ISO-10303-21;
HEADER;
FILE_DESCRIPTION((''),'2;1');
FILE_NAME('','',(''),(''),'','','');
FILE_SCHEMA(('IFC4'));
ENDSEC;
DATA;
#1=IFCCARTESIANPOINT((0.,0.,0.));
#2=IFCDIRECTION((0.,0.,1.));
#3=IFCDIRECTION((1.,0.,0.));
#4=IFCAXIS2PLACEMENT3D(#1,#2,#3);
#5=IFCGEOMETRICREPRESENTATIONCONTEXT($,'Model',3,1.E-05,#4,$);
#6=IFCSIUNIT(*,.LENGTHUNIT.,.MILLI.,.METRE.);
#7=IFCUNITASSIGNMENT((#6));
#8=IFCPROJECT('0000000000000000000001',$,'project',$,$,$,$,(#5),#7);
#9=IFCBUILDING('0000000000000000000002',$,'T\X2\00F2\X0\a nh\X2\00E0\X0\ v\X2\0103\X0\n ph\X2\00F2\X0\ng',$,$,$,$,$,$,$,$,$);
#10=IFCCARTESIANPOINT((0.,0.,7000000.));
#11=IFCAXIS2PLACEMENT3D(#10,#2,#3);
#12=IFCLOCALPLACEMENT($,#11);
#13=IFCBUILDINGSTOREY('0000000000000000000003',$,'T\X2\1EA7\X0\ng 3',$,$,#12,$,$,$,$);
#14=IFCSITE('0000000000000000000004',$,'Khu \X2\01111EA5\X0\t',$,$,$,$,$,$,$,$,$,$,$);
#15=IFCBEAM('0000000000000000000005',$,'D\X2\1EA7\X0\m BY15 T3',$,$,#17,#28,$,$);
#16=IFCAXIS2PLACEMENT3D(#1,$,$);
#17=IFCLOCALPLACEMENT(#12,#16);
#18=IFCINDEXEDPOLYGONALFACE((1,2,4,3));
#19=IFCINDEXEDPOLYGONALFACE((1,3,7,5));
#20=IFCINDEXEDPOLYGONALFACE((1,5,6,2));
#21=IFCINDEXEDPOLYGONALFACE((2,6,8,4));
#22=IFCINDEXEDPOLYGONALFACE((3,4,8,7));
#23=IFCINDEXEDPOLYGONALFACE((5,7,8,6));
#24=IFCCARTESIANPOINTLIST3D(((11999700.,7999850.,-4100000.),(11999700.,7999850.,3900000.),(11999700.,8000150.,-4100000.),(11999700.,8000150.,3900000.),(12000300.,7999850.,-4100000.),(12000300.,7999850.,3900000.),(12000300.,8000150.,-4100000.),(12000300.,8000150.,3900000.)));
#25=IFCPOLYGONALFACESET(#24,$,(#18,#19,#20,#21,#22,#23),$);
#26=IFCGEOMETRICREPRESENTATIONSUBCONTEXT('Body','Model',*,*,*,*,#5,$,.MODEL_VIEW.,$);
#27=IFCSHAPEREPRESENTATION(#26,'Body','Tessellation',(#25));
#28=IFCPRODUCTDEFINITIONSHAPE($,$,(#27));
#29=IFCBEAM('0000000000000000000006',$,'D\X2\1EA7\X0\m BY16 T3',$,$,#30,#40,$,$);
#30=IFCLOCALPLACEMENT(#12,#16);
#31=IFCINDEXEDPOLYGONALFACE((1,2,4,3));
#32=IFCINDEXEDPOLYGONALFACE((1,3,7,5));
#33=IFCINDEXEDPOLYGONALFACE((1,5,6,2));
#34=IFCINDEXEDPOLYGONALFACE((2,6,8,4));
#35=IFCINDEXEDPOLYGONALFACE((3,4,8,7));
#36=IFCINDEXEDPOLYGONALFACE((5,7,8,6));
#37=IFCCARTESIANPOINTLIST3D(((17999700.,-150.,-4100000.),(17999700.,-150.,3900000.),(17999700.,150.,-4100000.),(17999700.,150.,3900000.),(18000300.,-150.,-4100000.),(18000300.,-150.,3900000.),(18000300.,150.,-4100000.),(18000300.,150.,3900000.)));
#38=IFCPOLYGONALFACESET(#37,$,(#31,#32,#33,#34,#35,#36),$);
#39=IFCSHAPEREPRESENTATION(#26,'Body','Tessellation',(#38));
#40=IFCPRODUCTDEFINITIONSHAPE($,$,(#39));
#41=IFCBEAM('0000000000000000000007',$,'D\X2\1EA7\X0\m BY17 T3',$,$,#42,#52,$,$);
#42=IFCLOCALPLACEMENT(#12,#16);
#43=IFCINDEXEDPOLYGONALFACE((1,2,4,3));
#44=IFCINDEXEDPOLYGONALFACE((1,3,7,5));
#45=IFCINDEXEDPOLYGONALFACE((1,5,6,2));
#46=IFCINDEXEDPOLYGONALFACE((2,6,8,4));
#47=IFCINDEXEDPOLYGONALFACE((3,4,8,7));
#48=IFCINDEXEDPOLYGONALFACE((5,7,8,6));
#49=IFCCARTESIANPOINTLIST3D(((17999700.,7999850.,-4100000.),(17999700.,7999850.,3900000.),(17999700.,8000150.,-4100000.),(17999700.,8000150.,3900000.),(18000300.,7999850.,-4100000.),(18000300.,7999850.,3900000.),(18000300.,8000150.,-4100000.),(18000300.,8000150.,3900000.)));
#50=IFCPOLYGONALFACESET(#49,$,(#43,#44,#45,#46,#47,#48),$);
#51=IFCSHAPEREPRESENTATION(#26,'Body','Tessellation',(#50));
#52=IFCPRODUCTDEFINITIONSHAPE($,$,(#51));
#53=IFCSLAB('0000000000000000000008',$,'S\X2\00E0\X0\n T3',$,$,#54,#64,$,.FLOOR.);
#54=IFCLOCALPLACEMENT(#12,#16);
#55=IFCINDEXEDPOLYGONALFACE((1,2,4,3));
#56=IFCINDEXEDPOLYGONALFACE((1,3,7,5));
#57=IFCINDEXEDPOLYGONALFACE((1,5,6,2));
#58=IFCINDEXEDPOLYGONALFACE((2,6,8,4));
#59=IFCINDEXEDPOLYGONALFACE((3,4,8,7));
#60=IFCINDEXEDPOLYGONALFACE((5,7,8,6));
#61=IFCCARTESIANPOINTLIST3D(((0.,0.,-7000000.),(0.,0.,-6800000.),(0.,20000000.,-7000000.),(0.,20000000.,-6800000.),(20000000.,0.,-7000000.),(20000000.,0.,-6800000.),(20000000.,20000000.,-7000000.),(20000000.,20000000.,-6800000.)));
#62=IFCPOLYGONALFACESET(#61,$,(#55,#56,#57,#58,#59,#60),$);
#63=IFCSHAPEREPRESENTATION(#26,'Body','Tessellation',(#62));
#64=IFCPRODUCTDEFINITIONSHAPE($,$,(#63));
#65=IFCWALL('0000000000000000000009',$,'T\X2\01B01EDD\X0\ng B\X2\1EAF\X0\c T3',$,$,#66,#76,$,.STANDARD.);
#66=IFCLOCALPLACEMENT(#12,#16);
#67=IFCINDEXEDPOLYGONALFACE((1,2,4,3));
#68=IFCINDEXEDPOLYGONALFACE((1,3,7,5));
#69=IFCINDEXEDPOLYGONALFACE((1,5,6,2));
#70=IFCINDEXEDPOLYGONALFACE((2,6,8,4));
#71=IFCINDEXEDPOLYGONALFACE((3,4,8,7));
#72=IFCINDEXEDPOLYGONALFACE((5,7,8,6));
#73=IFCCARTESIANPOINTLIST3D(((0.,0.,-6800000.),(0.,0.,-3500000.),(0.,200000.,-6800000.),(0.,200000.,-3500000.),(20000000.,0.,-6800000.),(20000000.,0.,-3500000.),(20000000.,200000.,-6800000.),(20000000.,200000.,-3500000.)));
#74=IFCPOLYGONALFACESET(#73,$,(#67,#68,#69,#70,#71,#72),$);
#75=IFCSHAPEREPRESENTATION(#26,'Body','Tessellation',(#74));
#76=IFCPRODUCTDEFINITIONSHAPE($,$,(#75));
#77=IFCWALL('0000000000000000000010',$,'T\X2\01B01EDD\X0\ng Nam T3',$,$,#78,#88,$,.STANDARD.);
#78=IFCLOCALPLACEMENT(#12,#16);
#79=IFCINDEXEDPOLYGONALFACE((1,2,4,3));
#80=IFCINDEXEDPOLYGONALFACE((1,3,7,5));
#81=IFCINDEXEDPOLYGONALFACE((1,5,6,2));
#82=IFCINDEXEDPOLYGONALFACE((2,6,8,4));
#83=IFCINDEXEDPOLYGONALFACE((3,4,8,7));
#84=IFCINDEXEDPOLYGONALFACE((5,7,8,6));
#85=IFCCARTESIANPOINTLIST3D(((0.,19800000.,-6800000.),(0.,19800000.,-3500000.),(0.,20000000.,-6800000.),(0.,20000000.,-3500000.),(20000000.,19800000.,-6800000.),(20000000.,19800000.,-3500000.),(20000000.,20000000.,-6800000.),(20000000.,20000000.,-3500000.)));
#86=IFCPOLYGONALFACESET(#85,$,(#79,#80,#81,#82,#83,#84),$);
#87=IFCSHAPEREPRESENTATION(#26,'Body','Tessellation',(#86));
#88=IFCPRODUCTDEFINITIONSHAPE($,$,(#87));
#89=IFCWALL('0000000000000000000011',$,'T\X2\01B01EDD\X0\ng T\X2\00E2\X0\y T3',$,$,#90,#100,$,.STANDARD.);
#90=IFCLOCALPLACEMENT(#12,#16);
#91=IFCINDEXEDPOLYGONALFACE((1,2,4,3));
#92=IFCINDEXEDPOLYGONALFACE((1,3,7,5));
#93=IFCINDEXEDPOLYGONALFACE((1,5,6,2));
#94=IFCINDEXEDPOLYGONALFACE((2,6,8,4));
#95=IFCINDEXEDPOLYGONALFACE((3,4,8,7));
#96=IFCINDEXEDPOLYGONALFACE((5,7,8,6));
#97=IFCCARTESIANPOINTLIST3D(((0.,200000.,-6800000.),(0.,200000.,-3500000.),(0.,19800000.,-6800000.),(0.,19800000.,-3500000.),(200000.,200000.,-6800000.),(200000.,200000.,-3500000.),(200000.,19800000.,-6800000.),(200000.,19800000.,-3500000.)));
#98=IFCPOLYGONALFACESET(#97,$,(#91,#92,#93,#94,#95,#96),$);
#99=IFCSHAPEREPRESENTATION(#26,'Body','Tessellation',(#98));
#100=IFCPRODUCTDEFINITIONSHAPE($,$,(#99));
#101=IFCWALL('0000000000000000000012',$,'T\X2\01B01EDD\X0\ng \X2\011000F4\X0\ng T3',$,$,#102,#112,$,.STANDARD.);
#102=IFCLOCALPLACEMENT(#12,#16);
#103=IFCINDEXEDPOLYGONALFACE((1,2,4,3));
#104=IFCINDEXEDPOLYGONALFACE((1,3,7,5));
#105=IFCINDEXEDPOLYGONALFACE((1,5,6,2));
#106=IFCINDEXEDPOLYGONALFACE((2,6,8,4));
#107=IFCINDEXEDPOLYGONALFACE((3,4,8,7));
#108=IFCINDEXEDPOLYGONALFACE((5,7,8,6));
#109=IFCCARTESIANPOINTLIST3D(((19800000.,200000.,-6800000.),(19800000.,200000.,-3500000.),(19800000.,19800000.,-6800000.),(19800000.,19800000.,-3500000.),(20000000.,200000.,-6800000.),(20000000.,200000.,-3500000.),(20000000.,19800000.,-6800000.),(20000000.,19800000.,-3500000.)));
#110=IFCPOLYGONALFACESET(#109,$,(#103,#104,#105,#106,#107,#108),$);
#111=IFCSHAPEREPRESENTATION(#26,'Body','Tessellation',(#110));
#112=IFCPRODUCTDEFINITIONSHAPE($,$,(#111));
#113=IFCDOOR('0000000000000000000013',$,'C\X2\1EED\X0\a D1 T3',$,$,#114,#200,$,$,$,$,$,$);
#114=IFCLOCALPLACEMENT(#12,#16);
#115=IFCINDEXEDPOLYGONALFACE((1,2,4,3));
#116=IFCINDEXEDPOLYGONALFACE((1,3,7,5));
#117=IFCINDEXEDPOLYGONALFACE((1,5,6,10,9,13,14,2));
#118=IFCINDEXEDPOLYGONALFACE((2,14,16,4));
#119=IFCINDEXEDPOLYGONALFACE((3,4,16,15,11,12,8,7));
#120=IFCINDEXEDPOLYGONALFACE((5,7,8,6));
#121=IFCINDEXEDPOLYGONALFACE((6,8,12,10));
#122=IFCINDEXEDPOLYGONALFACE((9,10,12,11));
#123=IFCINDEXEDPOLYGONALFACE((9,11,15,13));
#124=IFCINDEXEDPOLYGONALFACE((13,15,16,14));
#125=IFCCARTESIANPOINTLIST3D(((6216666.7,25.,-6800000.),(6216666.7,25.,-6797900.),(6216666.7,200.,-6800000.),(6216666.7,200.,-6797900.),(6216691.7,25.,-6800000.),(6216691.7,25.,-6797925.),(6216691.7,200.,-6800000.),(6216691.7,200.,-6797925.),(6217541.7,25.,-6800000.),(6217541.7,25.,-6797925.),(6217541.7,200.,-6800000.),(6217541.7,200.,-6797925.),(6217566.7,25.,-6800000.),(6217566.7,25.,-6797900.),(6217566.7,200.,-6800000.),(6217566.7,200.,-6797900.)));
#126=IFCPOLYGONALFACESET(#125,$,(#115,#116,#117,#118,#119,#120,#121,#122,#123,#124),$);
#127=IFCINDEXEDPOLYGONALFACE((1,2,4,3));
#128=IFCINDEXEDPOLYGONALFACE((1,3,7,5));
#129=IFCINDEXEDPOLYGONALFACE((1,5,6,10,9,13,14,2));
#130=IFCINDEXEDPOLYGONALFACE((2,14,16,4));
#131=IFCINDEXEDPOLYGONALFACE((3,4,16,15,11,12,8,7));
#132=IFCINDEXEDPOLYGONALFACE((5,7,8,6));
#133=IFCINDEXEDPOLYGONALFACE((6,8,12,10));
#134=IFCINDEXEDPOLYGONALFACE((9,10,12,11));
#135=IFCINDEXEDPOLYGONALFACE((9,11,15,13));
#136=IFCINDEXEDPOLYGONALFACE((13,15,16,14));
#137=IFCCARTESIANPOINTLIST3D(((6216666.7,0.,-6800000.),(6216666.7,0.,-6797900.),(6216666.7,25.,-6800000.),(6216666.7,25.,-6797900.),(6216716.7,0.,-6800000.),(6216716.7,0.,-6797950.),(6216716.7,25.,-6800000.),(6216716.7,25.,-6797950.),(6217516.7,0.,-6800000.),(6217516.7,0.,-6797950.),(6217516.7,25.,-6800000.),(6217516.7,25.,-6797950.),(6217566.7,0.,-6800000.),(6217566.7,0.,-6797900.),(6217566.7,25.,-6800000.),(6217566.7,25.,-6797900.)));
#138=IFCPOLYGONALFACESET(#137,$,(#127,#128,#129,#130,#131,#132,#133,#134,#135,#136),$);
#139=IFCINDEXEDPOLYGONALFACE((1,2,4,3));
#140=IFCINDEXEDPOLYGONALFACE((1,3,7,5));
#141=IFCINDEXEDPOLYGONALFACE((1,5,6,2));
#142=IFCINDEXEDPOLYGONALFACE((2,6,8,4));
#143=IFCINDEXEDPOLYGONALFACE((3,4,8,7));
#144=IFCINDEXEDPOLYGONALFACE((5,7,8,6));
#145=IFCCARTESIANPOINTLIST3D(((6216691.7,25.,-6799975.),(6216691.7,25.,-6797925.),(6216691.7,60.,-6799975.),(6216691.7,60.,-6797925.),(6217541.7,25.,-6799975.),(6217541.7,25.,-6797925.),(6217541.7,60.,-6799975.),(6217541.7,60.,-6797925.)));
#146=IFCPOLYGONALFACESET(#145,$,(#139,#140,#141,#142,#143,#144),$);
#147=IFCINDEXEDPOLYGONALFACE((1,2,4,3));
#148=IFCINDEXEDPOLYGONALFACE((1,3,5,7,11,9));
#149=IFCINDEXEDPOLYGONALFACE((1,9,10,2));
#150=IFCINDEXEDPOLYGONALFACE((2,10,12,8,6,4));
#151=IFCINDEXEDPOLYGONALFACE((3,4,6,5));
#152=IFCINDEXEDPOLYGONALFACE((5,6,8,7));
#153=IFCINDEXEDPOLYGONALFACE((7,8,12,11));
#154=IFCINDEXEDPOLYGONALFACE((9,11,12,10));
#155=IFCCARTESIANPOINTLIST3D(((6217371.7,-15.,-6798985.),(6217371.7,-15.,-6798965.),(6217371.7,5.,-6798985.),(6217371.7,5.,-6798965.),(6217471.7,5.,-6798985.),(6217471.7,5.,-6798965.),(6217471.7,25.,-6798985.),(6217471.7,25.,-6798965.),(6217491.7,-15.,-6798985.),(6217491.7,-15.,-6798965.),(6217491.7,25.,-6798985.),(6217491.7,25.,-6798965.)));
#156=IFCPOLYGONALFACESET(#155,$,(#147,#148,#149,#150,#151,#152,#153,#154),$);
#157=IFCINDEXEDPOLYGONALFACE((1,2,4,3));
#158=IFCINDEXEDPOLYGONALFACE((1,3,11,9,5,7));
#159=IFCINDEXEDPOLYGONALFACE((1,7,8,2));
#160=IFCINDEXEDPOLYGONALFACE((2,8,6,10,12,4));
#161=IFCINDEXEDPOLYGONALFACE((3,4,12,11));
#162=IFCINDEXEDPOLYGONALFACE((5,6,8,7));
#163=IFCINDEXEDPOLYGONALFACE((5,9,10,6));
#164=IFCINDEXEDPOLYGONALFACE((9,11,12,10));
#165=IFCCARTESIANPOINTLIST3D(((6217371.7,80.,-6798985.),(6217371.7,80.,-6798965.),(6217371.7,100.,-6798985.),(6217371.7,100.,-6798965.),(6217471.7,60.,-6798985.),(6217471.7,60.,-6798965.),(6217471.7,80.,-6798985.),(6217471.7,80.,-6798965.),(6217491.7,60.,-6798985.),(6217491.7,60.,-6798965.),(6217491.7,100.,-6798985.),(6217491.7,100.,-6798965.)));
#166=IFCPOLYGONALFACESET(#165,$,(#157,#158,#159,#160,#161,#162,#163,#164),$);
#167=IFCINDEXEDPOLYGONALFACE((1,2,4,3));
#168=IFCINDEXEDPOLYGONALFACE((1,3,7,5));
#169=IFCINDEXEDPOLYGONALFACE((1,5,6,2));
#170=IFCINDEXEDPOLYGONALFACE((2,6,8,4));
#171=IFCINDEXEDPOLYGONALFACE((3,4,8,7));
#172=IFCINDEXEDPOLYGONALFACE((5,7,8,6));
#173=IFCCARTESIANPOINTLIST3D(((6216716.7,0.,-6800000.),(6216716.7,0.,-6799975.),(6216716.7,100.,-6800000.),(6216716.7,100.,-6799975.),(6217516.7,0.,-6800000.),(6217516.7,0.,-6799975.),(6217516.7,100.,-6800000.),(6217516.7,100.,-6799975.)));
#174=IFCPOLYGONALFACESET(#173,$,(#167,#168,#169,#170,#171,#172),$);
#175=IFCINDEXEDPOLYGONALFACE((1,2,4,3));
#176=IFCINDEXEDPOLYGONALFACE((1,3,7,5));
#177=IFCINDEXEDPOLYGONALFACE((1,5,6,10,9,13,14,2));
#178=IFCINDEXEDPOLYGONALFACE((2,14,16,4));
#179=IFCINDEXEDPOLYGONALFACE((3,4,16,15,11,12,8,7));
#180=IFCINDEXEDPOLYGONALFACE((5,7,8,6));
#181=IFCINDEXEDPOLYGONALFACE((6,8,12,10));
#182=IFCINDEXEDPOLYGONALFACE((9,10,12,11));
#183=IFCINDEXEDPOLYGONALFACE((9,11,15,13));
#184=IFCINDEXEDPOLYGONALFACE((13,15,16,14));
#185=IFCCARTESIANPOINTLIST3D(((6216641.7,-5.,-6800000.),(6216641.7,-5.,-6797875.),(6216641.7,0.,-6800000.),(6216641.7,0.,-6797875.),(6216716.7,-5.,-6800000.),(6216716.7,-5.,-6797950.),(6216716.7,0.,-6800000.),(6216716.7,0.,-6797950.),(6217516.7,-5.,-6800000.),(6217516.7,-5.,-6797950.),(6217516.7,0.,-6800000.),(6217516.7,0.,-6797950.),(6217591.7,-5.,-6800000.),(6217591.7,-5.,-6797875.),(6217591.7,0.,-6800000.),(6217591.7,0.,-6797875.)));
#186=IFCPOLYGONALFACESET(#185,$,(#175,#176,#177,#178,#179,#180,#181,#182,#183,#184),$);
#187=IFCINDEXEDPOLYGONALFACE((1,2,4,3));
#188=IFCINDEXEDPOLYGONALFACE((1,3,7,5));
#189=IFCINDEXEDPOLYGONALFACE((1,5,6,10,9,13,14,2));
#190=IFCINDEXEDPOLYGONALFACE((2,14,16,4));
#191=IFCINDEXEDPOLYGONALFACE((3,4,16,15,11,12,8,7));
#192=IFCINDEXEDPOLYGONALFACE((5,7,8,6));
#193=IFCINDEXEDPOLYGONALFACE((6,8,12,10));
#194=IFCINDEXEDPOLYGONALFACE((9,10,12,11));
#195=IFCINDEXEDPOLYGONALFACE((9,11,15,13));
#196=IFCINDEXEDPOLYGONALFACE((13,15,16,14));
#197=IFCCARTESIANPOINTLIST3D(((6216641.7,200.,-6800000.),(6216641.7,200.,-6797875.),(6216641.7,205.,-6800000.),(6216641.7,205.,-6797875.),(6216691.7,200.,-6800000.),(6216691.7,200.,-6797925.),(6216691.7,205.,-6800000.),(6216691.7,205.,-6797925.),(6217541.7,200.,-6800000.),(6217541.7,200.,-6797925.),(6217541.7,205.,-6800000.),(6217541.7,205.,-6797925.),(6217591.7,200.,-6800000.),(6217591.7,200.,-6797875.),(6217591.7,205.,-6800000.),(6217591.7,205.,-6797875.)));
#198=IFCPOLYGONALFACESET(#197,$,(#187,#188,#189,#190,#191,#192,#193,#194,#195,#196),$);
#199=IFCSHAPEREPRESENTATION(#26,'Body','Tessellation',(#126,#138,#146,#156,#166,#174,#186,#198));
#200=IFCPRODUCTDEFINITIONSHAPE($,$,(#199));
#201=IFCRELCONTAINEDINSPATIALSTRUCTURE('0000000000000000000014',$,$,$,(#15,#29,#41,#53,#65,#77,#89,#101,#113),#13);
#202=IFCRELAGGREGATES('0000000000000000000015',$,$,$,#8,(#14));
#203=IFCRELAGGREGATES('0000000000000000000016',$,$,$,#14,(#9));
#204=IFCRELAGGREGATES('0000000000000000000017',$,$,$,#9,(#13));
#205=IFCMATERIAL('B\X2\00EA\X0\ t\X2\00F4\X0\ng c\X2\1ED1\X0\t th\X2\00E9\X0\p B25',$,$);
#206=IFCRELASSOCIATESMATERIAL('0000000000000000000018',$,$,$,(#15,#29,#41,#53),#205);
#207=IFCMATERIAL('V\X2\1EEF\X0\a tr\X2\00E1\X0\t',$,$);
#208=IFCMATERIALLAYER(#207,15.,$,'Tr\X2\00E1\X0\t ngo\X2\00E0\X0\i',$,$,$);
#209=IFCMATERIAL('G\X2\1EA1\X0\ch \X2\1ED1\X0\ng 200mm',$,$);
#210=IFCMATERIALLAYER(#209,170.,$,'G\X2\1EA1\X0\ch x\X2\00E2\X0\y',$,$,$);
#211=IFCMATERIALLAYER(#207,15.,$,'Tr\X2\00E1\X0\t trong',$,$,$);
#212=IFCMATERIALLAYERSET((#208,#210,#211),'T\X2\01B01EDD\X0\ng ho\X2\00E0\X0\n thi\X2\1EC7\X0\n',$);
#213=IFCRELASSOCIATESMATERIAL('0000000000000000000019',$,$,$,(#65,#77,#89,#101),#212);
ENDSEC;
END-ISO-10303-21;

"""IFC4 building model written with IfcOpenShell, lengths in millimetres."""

from ifc_helpers import new_model, entity, si_unit, frame, origin_with_axes, place, context, subcontext, project, spatial, line, indexed_curve, outline, extrude, material, layer, layer_set, layer_usage, element, save


model = new_model("IFC4")

# Units and contexts
model_context = context("Model", 3, precision=1e-05, world=origin_with_axes())
body_context = subcontext(model_context, "Body", "Model", "MODEL_VIEW")
ifc_project = project(units=[si_unit("LENGTHUNIT", "METRE", prefix="MILLI")], contexts=[model_context])

# Site, building, storey
site = spatial("IfcSite", under=ifc_project, Name="Khu đất")
building = spatial("IfcBuilding", under=site, Name="Tòa nhà văn phòng")
storey_placement = place(None, frame((0.0, 0.0, 7000000.0), z_axis=(0.0, 0.0, 1.0), x_axis=(1.0, 0.0, 0.0)))
storey = spatial("IfcBuildingStorey", under=building, at=storey_placement, Name="Tầng 3")

# Shared definitions
ifc_material_1 = material(Name="Bê tông cốt thép B25")

# Beams
for number, where, z_axis, x_axis, name in (
    (1, (12000000.0, 8000000.0, -4100000.0), (0.0, 0.0, 1.0), (0.0, 1.0, 0.0), "Dầm BY15 T3"),
    (2, (18000000.0, 0.0, -4100000.0), (0.0, 0.0, 1.0), (0.0, 1.0, 0.0), "Dầm BY16 T3"),
    (3, (18000000.0, 8000000.0, -4100000.0), (0.0, 0.0, 1.0), (0.0, 1.0, 0.0), "Dầm BY17 T3"),
):
    element("IfcBeam", number, at=place(storey_placement, frame(where, z_axis=z_axis, x_axis=x_axis)), inside=storey, material=ifc_material_1, Name=name, context=body_context, shape_type="SweptSolid", body=[
        extrude(entity("IfcRectangleProfileDef", None, None, None, 300.0, 600.0), origin_with_axes(), (0.0, 0.0, 1.0), 8000000.0),
    ])

# Slab
slab_placement = place(storey_placement, frame((0.0, 0.0, -7000000.0), z_axis=(0.0, 0.0, 1.0), x_axis=(1.0, 0.0, 0.0)))
element("IfcSlab", 4, at=slab_placement, inside=storey, material=ifc_material_1, Name="Sàn T3", PredefinedType="FLOOR", context=body_context, shape_type="SweptSolid", body=[
    extrude(outline(indexed_curve([(0.0, 0.0), (20000000.0, 0.0), (20000000.0, 20000000.0), (0.0, 20000000.0), (0.0, 0.0)])), None, (0.0, 0.0, 1.0), 200000.0),
])

# Walls
ifc_material_2 = material(Name="Vữa trát")
ifc_layer_1 = layer(ifc_material_2, 15.0, Name="Trát ngoài")
ifc_material_3 = material(Name="Gạch ống 200mm")
ifc_layer_2 = layer(ifc_material_3, 170.0, Name="Gạch xây")
ifc_layer_3 = layer(ifc_material_2, 15.0, Name="Trát trong")
ifc_layer_set = layer_set([ifc_layer_1, ifc_layer_2, ifc_layer_3], Name="Tường hoàn thiện")
ifc_layer_usage_1 = layer_usage(ifc_layer_set, "AXIS2", "POSITIVE", 0.0)
wall_1_placement = place(storey_placement, frame((0.0, 0.0, -6800000.0), z_axis=(0.0, 0.0, 1.0), x_axis=(1.0, 0.0, 0.0)))
element("IfcWall", 5, at=wall_1_placement, inside=storey, material=ifc_layer_usage_1, Name="Tường Bắc T3", PredefinedType="STANDARD", context=body_context, shape_type="SweptSolid", body=[
    extrude(outline(indexed_curve([(0.0, 0.0), (0.0, 200000.0), (20000000.0, 200000.0), (20000000.0, 0.0), (0.0, 0.0)], self_intersect=False)), origin_with_axes(), (0.0, 0.0, 1.0), 3300000.0),
])
ifc_layer_usage_2 = layer_usage(ifc_layer_set, "AXIS2", "POSITIVE", 0.0)
wall_2_placement = place(storey_placement, frame((0.0, 19800000.0, -6800000.0), z_axis=(0.0, 0.0, 1.0), x_axis=(1.0, 0.0, 0.0)))
element("IfcWall", 6, at=wall_2_placement, inside=storey, material=ifc_layer_usage_2, Name="Tường Nam T3", PredefinedType="STANDARD", context=body_context, shape_type="SweptSolid", body=[
    extrude(outline(indexed_curve([(0.0, 0.0), (0.0, 200000.0), (20000000.0, 200000.0), (20000000.0, 0.0), (0.0, 0.0)], self_intersect=False)), origin_with_axes(), (0.0, 0.0, 1.0), 3300000.0),
])
ifc_layer_usage_3 = layer_usage(ifc_layer_set, "AXIS2", "POSITIVE", 0.0)
wall_3_placement = place(storey_placement, frame((0.0, 200000.0, -6800000.0), z_axis=(0.0, 0.0, 1.0), x_axis=(1.0, 0.0, 0.0)))
element("IfcWall", 7, at=wall_3_placement, inside=storey, material=ifc_layer_usage_3, Name="Tường Tây T3", PredefinedType="STANDARD", context=body_context, shape_type="SweptSolid", body=[
    extrude(outline(indexed_curve([(0.0, 0.0), (0.0, 19600000.0), (200000.0, 19600000.0), (200000.0, 0.0), (0.0, 0.0)], self_intersect=False)), origin_with_axes(), (0.0, 0.0, 1.0), 3300000.0),
])
ifc_layer_usage_4 = layer_usage(ifc_layer_set, "AXIS2", "POSITIVE", 0.0)
wall_4_placement = place(storey_placement, frame((19800000.0, 200000.0, -6800000.0), z_axis=(0.0, 0.0, 1.0), x_axis=(1.0, 0.0, 0.0)))
element("IfcWall", 8, at=wall_4_placement, inside=storey, material=ifc_layer_usage_4, Name="Tường Đông T3", PredefinedType="STANDARD", context=body_context, shape_type="SweptSolid", body=[
    extrude(outline(indexed_curve([(0.0, 0.0), (0.0, 19600000.0), (200000.0, 19600000.0), (200000.0, 0.0), (0.0, 0.0)], self_intersect=False)), origin_with_axes(), (0.0, 0.0, 1.0), 3300000.0),
])

# Door
door_1_placement = place(storey_placement, frame((6216666.7, 0.0, -6800000.0), z_axis=(0.0, 0.0, 1.0), x_axis=(1.0, 0.0, 0.0)))
element("IfcDoor", 9, at=door_1_placement, inside=storey, Name="Cửa D1 T3", context=body_context, shape_type="SolidModel", body=[
    extrude(outline(indexed_curve([(0.0, 0.0), (0.0, 2100.0), (900.0, 2100.0), (900.0, 0.0), (875.0, 0.0), (875.0, 2075.0), (25.0, 2075.0), (25.0, 0.0)], segments=[line(1, 2, 3, 4, 5, 6, 7, 8, 1)])), frame((0.0, 25.0, 0.0), z_axis=(0.0, -1.0, 0.0), x_axis=(1.0, 0.0, 0.0)), (0.0, 0.0, -1.0), 175.0),
    extrude(outline(indexed_curve([(0.0, 0.0), (0.0, 2100.0), (900.0, 2100.0), (900.0, 0.0), (850.0, 0.0), (850.0, 2050.0), (50.0, 2050.0), (50.0, 0.0)], segments=[line(1, 2, 3, 4, 5, 6, 7, 8, 1)])), frame((0.0, 0.0, 0.0), z_axis=(0.0, -1.0, 0.0), x_axis=(1.0, 0.0, 0.0)), (0.0, 0.0, -1.0), 25.0),
    extrude(outline(indexed_curve([(0.0, 0.0), (850.0, 0.0), (850.0, 35.0), (0.0, 35.0)], segments=[line(1, 2, 3, 4, 1)])), frame((25.0, 25.0, 25.0), z_axis=(0.0, 0.0, 1.0), x_axis=(1.0, 0.0, 0.0)), (0.0, 0.0, 1.0), 2050.0),
    extrude(outline(indexed_curve([(0.0, 0.0), (0.0, -40.0), (-120.0, -40.0), (-120.0, -20.0), (-20.0, -20.0), (-20.0, 0.0)], segments=[line(1, 2, 3, 4, 5, 6, 1)])), frame((825.0, 25.0, 1015.0), z_axis=(0.0, 0.0, 1.0), x_axis=(1.0, 0.0, 0.0)), (0.0, 0.0, 1.0), 20.0),
    extrude(outline(indexed_curve([(0.0, 0.0), (0.0, 40.0), (-120.0, 40.0), (-120.0, 20.0), (-20.0, 20.0), (-20.0, 0.0)], segments=[line(1, 2, 3, 4, 5, 6, 1)])), frame((825.0, 60.0, 1015.0), z_axis=(0.0, 0.0, 1.0), x_axis=(1.0, 0.0, 0.0)), (0.0, 0.0, 1.0), 20.0),
    extrude(outline(indexed_curve([(0.0, 0.0), (800.0, 0.0), (800.0, 100.0), (0.0, 100.0)], segments=[line(1, 2, 3, 4, 1)])), frame((50.0, 0.0, 0.0), z_axis=(0.0, 0.0, 1.0), x_axis=(1.0, 0.0, 0.0)), (0.0, 0.0, 1.0), 25.0),
    extrude(outline(indexed_curve([(0.0, 0.0), (0.0, 2125.0), (950.0, 2125.0), (950.0, 0.0), (875.0, 0.0), (875.0, 2050.0), (75.0, 2050.0), (75.0, 0.0)], segments=[line(1, 2, 3, 4, 5, 6, 7, 8, 1)])), frame((-25.0, -5.0, 0.0), z_axis=(0.0, -1.0, 0.0), x_axis=(1.0, 0.0, 0.0)), (0.0, 0.0, -1.0), 5.0),
    extrude(outline(indexed_curve([(0.0, 0.0), (0.0, 2125.0), (950.0, 2125.0), (950.0, 0.0), (900.0, 0.0), (900.0, 2075.0), (50.0, 2075.0), (50.0, 0.0)], segments=[line(1, 2, 3, 4, 5, 6, 7, 8, 1)])), frame((-25.0, 200.0, 0.0), z_axis=(0.0, -1.0, 0.0), x_axis=(1.0, 0.0, 0.0)), (0.0, 0.0, -1.0), 5.0),
])

save(model, "model.ifc")
